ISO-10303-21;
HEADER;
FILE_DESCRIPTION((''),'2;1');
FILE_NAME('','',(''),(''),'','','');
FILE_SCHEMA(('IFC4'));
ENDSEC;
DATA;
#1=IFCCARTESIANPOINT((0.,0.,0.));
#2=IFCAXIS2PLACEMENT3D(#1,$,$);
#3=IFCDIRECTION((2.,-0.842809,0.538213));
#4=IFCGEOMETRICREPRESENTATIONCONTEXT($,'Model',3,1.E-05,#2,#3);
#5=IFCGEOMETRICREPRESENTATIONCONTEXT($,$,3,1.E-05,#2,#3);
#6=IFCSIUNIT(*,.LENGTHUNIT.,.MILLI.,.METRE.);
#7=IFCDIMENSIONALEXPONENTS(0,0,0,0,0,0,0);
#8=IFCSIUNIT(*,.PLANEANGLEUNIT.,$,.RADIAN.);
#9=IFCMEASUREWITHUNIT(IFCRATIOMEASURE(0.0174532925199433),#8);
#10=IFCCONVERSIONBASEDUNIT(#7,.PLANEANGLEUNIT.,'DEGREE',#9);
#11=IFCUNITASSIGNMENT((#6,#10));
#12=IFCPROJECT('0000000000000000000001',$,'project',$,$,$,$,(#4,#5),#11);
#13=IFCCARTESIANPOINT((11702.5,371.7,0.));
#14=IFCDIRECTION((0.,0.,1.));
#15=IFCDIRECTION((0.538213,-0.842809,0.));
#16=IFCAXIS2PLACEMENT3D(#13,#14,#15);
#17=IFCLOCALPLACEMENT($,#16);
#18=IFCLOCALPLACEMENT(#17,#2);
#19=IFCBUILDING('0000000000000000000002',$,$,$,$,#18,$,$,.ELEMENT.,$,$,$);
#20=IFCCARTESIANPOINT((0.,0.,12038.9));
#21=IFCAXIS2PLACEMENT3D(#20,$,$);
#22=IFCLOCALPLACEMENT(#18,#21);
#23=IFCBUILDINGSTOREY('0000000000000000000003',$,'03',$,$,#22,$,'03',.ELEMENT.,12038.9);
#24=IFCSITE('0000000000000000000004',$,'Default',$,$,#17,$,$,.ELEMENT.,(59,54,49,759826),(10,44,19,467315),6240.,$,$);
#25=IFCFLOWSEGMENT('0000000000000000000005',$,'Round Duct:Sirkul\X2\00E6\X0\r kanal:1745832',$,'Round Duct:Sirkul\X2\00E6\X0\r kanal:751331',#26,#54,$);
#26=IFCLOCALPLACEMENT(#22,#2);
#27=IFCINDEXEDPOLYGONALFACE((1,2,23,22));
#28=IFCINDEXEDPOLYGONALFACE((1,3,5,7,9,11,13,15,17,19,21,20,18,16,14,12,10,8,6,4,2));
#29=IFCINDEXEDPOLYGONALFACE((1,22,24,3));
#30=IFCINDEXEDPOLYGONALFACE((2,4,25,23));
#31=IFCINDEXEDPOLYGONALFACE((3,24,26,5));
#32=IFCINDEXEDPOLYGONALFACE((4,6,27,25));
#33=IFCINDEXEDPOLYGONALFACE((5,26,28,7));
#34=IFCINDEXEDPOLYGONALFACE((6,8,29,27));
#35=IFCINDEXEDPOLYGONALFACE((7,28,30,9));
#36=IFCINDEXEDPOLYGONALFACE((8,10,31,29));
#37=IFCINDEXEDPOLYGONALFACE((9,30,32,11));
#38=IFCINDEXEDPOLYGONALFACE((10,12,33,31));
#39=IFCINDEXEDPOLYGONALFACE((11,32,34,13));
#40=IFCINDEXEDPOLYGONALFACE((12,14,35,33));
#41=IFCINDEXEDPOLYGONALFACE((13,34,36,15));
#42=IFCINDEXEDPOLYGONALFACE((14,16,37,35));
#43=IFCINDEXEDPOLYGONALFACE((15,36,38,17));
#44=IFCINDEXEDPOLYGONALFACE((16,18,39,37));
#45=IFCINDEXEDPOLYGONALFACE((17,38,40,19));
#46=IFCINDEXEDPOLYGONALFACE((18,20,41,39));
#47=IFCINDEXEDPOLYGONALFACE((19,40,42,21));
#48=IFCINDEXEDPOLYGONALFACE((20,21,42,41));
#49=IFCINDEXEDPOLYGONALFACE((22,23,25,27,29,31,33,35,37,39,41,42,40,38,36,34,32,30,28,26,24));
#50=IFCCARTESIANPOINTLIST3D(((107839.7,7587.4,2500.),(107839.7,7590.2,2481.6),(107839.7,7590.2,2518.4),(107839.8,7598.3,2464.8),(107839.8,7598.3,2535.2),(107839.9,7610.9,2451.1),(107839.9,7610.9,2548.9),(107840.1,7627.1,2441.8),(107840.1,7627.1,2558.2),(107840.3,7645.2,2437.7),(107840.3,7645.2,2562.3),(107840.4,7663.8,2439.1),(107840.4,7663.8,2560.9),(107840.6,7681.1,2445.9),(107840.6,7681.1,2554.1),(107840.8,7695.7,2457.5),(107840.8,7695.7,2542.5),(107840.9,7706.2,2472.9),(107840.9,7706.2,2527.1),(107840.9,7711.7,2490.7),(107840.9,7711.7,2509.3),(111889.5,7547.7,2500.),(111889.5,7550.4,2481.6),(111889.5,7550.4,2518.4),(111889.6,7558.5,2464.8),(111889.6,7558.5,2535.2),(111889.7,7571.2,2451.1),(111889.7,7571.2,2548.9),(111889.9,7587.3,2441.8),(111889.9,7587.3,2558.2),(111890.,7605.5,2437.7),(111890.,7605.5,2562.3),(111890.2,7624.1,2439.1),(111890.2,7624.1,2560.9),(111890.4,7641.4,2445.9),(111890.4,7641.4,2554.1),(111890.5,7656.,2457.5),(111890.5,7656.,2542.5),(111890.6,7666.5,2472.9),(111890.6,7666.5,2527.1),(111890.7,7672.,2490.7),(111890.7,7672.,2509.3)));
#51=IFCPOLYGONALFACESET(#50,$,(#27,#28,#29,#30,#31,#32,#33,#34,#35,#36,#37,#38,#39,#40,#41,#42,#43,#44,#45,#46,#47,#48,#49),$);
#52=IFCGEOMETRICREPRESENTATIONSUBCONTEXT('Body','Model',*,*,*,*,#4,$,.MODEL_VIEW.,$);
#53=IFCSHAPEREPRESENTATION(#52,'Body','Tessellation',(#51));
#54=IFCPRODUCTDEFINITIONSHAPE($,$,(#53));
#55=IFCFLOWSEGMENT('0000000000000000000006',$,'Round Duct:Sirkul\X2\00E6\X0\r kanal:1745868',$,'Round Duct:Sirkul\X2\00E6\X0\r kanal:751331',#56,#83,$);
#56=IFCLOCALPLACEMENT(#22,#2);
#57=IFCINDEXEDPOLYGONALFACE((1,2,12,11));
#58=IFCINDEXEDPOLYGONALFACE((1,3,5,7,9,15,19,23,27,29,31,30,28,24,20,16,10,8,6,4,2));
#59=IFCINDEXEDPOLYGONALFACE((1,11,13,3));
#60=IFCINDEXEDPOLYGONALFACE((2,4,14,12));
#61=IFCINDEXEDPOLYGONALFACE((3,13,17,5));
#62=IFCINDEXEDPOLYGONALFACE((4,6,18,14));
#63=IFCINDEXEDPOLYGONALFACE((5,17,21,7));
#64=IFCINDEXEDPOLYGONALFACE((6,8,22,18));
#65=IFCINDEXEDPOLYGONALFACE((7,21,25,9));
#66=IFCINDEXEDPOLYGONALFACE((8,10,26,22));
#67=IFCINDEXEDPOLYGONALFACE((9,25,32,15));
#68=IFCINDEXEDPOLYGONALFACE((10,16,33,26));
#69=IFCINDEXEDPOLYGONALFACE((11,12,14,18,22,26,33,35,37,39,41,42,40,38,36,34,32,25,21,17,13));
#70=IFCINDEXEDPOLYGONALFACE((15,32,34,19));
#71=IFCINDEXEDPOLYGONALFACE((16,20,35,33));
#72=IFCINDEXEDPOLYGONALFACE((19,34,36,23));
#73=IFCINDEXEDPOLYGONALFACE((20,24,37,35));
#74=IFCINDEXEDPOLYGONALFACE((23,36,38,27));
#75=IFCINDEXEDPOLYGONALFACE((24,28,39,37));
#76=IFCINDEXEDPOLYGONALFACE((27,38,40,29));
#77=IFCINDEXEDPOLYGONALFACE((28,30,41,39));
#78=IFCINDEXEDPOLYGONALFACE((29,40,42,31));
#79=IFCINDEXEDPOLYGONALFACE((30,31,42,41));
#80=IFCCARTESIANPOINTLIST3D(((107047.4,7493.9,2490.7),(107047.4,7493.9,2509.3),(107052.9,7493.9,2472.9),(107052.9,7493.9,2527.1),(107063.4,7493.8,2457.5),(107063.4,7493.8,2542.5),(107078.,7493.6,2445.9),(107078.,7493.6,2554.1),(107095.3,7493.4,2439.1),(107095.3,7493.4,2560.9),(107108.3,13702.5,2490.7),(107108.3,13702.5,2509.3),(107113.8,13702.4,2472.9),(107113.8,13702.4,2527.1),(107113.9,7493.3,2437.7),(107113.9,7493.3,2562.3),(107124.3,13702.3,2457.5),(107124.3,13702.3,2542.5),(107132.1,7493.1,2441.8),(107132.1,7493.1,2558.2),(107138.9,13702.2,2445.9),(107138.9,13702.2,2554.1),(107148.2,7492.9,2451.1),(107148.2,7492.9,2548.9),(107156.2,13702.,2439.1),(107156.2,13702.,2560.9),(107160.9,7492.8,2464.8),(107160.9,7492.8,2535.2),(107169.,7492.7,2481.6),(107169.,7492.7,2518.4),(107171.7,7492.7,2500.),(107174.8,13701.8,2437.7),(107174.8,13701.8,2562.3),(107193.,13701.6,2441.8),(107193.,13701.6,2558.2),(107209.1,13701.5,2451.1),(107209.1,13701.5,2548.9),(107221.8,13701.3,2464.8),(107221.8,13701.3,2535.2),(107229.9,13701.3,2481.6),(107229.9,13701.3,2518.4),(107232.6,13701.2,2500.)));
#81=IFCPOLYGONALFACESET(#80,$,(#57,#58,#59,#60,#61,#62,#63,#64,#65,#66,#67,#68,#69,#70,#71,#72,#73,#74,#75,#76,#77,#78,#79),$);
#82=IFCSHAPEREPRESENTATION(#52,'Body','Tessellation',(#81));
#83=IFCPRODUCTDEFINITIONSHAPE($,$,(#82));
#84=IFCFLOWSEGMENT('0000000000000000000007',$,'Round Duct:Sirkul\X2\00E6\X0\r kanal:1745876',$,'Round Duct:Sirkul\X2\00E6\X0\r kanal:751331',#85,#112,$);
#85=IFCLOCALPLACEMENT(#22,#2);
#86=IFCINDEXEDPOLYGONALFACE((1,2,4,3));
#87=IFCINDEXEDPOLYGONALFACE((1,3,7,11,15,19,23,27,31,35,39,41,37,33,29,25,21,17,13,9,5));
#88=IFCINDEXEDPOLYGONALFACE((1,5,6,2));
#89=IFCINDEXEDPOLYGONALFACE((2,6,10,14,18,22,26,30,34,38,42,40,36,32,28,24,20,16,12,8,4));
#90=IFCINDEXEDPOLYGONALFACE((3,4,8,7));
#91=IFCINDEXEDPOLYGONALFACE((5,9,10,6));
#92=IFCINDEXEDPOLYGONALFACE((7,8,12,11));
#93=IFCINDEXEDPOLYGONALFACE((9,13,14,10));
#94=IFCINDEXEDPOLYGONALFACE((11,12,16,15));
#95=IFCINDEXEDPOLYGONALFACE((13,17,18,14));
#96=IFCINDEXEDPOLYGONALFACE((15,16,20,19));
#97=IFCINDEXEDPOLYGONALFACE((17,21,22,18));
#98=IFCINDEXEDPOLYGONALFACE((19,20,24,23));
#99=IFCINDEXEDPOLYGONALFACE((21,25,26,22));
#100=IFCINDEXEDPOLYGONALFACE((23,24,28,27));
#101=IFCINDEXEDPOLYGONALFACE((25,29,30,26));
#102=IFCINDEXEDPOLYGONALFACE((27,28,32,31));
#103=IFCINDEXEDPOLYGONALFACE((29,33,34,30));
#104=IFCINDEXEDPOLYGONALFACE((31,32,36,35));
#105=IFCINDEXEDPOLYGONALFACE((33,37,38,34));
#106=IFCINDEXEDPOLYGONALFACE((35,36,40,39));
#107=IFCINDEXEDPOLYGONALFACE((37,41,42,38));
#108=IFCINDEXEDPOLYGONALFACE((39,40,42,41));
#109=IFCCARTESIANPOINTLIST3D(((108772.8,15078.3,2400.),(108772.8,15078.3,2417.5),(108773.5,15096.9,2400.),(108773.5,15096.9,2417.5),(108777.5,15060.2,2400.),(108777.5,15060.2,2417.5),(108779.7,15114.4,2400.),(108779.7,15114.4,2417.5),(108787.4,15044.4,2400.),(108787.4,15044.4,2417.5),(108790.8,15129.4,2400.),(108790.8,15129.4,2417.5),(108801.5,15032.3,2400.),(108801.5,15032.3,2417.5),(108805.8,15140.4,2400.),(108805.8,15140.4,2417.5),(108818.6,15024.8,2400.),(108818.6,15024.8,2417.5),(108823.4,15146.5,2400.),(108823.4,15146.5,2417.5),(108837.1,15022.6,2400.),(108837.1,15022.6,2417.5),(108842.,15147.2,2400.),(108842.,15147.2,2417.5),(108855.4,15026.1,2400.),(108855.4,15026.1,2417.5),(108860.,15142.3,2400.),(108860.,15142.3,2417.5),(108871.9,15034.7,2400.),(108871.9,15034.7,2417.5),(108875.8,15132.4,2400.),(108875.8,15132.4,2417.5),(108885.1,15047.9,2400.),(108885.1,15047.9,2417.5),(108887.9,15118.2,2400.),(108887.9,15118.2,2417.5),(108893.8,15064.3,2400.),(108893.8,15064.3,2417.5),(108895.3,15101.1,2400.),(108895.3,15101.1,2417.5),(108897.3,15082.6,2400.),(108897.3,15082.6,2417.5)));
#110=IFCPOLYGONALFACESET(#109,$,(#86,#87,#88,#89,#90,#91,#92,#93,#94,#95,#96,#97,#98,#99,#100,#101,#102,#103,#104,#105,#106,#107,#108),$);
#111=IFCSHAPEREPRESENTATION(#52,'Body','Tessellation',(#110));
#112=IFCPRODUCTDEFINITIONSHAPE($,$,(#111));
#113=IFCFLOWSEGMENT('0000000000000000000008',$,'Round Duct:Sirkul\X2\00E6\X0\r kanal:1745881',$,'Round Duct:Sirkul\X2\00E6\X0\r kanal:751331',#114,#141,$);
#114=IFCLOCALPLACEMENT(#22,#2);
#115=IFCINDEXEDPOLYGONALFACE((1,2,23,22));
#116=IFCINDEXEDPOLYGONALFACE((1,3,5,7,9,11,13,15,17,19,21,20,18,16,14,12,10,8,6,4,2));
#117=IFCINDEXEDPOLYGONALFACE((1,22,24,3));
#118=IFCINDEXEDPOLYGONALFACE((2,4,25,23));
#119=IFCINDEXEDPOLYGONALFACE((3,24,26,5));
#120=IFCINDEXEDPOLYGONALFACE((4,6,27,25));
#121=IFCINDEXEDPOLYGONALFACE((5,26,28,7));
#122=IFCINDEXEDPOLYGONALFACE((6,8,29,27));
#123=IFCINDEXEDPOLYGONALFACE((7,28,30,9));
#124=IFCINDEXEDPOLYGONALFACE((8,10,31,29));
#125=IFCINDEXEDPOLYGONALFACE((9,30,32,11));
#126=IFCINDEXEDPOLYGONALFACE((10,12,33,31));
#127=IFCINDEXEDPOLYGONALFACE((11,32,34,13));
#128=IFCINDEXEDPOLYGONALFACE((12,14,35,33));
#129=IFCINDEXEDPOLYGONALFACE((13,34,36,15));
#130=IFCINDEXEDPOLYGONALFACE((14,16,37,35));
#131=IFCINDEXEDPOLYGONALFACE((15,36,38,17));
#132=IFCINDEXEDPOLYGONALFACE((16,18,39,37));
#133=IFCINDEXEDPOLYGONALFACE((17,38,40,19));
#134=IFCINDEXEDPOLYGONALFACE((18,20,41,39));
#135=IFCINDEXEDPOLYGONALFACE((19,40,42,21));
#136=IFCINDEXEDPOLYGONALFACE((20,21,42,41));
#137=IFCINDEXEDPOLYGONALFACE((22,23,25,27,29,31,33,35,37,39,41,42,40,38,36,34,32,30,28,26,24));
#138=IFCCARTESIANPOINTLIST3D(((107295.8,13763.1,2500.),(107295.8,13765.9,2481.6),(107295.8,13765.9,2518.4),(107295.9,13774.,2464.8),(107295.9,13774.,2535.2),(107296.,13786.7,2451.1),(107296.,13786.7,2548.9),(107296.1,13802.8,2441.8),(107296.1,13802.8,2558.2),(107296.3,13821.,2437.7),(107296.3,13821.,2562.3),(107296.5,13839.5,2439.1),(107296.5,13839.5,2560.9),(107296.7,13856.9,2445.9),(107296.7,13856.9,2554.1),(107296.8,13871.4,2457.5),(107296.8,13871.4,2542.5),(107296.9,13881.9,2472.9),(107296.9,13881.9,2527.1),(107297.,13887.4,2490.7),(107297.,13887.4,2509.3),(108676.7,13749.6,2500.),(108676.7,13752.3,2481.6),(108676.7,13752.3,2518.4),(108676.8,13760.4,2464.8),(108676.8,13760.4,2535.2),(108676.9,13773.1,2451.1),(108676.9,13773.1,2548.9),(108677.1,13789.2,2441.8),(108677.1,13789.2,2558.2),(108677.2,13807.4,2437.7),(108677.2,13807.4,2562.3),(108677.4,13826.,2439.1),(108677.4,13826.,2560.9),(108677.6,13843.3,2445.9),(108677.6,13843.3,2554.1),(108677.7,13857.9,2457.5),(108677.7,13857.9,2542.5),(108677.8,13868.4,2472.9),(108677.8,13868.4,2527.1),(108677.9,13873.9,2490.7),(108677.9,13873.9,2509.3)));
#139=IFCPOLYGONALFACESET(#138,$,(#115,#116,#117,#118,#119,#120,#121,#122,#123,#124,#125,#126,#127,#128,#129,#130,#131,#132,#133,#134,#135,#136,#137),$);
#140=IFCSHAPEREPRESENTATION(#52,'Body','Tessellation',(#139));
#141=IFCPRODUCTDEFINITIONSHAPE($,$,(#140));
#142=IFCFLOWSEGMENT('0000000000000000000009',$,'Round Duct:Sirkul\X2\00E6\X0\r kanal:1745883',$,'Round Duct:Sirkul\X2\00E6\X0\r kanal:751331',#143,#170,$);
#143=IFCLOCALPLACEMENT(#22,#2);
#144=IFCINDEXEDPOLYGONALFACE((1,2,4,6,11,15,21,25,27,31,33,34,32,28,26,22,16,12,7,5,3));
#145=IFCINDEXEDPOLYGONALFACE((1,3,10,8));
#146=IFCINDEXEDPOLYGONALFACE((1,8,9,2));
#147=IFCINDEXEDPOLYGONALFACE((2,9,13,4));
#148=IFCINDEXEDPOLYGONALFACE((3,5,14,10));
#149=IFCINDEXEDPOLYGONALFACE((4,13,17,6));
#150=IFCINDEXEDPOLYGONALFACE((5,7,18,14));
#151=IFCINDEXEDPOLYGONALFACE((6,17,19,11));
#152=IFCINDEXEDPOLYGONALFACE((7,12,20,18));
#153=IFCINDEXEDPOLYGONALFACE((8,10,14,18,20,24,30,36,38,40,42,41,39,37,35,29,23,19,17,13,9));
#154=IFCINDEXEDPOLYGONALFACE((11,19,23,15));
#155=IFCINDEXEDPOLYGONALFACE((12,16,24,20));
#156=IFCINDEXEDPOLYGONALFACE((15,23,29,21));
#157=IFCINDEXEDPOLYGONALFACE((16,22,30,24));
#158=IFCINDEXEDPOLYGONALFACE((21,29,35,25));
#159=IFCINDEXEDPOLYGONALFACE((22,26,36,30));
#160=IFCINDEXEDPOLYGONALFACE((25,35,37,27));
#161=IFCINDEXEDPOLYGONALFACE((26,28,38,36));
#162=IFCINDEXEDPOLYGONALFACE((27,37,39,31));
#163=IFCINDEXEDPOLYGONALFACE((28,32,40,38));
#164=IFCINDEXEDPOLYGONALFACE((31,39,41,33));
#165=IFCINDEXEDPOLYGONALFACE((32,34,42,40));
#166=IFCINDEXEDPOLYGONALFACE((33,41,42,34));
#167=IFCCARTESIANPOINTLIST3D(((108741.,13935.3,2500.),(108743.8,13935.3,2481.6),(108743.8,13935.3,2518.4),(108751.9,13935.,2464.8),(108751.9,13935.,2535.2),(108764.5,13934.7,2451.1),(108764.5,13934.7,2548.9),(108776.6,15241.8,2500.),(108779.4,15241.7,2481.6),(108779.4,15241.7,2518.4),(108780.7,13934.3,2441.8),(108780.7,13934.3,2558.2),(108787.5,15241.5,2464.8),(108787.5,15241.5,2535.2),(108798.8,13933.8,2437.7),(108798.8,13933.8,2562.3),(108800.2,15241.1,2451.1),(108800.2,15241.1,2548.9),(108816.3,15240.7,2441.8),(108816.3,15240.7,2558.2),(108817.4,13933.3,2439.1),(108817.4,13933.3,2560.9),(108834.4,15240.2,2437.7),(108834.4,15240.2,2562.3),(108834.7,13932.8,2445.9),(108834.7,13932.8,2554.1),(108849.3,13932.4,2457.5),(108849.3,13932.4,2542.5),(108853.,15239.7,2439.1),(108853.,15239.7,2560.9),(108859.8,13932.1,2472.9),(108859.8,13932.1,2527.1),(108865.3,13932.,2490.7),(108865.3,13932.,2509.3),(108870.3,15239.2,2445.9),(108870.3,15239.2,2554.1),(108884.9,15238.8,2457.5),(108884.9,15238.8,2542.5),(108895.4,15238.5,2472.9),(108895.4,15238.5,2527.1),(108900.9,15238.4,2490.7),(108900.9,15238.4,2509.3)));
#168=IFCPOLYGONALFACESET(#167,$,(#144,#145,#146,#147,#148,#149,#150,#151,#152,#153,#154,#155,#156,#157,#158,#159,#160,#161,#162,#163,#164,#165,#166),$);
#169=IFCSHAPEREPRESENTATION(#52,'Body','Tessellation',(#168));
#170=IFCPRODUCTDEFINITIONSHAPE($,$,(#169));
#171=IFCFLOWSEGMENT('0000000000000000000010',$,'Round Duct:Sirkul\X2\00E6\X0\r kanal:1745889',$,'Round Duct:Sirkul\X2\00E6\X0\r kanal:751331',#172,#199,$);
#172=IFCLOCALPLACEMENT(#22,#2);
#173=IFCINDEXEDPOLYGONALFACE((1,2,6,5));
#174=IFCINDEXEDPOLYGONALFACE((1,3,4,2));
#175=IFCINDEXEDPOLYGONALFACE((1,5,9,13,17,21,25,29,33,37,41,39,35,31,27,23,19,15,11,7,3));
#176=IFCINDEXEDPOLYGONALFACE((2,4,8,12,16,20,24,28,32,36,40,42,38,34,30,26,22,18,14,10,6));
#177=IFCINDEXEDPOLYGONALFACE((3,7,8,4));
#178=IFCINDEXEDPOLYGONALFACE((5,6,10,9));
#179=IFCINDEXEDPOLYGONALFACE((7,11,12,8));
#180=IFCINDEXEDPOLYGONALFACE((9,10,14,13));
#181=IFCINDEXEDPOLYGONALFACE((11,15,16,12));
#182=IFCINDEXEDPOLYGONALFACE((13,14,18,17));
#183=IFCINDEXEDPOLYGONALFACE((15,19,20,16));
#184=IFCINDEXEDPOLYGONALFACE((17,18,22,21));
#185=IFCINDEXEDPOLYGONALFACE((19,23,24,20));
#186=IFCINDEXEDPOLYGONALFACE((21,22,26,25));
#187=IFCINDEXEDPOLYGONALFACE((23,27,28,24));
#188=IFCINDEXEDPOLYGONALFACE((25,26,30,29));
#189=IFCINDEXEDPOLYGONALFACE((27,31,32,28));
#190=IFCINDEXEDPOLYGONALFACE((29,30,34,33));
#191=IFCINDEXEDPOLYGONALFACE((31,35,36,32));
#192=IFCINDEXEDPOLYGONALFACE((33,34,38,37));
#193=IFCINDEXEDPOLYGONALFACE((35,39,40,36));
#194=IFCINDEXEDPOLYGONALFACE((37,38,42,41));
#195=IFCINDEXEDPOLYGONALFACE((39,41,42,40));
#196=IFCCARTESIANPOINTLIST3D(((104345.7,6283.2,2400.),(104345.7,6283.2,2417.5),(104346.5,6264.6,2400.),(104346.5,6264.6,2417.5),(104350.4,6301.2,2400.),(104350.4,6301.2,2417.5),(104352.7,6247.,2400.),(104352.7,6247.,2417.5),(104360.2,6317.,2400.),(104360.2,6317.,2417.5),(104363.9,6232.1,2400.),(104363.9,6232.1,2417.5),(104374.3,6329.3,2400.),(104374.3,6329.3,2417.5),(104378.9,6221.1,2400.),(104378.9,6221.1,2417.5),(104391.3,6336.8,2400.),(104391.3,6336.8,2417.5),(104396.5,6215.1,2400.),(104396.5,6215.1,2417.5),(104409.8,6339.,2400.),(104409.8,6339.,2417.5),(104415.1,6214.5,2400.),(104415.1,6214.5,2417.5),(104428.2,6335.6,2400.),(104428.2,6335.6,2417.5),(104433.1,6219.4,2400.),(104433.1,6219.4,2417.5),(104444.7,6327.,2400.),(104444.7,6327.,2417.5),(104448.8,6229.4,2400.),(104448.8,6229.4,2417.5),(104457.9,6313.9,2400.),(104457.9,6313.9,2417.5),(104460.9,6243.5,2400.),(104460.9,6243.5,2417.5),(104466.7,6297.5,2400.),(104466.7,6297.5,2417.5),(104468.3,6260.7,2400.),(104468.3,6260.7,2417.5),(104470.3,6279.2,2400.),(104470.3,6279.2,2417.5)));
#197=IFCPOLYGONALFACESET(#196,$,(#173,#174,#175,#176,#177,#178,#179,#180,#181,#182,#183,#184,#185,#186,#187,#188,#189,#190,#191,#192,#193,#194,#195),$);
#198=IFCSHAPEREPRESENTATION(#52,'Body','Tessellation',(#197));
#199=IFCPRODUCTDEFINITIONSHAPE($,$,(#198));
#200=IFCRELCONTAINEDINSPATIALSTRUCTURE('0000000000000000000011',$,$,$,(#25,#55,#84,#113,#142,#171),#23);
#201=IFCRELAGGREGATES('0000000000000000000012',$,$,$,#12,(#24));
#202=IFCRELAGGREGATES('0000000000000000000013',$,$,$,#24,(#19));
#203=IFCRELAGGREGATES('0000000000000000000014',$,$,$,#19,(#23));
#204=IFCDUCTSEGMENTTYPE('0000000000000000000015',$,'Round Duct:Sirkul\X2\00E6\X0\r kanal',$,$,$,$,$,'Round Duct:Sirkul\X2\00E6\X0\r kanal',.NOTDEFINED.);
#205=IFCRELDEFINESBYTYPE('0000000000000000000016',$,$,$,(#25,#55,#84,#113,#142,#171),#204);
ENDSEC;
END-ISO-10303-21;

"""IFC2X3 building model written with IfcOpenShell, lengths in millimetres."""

from ifc_helpers import new_model, entity, si_unit, converted_unit, direction, frame, frame_2d, origin, origin_2d_with_axis, place, context, subcontext, project, spatial, circle, extrude, type_object, element, save


model = new_model("IFC2X3")

# Units and contexts
model_context = context("Model", 3, precision=1e-05, world=origin(), true_north=direction((2.0, -0.842809, 0.538213)))
context_of_model = context(None, 3, precision=1e-05, world=origin(), true_north=direction((2.0, -0.842809, 0.538213)))
body_context = subcontext(model_context, "Body", "Model", "MODEL_VIEW")
ifc_project = project(units=[si_unit("LENGTHUNIT", "METRE", prefix="MILLI"), converted_unit("PLANEANGLEUNIT", "DEGREE", entity("IfcRatioMeasure", 0.0174532925199433), si_unit("PLANEANGLEUNIT", "RADIAN"), dimensions=[0, 0, 0, 0, 0, 0, 0])], contexts=[model_context, context_of_model])

# Site, building, storey
site_placement = place(None, frame((11702.5, 371.7, 0.0), z_axis=(0.0, 0.0, 1.0), x_axis=(0.538213, -0.842809, 0.0)))
site = spatial("IfcSite", under=ifc_project, at=site_placement, Name="Default", CompositionType="ELEMENT", RefLatitude=(59, 54, 49, 759826), RefLongitude=(10, 44, 19, 467315), RefElevation=6240.0)
building_placement = place(site_placement, origin())
building = spatial("IfcBuilding", under=site, at=building_placement, CompositionType="ELEMENT")
storey_placement = place(building_placement, frame((0.0, 0.0, 12038.9)))
storey = spatial("IfcBuildingStorey", under=building, at=storey_placement, Name="03", LongName="03", CompositionType="ELEMENT", Elevation=12038.9)

# Flow segments
duct_segment_type = type_object("IfcDuctSegmentType", Name="Round Duct:Sirkulær kanal", ElementType="Round Duct:Sirkulær kanal", PredefinedType="NOTDEFINED")
flow_segment_1_placement = place(storey_placement, origin())
element("IfcFlowSegment", 1, at=flow_segment_1_placement, inside=storey, type_object=duct_segment_type, Name="Round Duct:Sirkulær kanal:1745832", ObjectType="Round Duct:Sirkulær kanal:751331", context=body_context, shape_type="SweptSolid", body=[
    extrude(circle(Radius=62.5, at=origin_2d_with_axis()), frame((107840.3, 7649.9, 2500.0), z_axis=(0.999952, -0.00981, 0.0), x_axis=(-0.00981, -0.999952, 0.0)), (0.0, 0.0, 1.0), 4050.0),
])
flow_segment_2_placement = place(storey_placement, origin())
element("IfcFlowSegment", 2, at=flow_segment_2_placement, inside=storey, type_object=duct_segment_type, Name="Round Duct:Sirkulær kanal:1745868", ObjectType="Round Duct:Sirkulær kanal:751331", context=body_context, shape_type="SweptSolid", body=[
    extrude(circle(Radius=62.5, at=origin_2d_with_axis()), frame((107109.2, 7493.3, 2500.0), z_axis=(0.00981, 0.999952, 0.0), x_axis=(0.999952, -0.00981, 0.0)), (0.0, 0.0, 1.0), 6208.9),
])
flow_segment_3_placement = place(storey_placement, origin())
element("IfcFlowSegment", 3, at=flow_segment_3_placement, inside=storey, type_object=duct_segment_type, Name="Round Duct:Sirkulær kanal:1745876", ObjectType="Round Duct:Sirkulær kanal:751331", context=body_context, shape_type="SweptSolid", body=[
    extrude(circle(Radius=62.5, at=frame_2d((0.0, 0.0), x_axis=(1.0, 0.0))), frame((108834.9, 15085.1, 2400.0), z_axis=(0.0, 0.0, 1.0), x_axis=(0.803212, -0.595694, 0.0)), (0.0, 0.0, 1.0), 17.5),
])
flow_segment_4_placement = place(storey_placement, origin())
element("IfcFlowSegment", 4, at=flow_segment_4_placement, inside=storey, type_object=duct_segment_type, Name="Round Duct:Sirkulær kanal:1745881", ObjectType="Round Duct:Sirkulær kanal:751331", context=body_context, shape_type="SweptSolid", body=[
    extrude(circle(Radius=62.5, at=frame_2d((0.0, 0.0), x_axis=(1.0, 0.0))), frame((107296.4, 13825.6, 2500.0), z_axis=(0.999952, -0.009828, 0.0), x_axis=(-0.009828, -0.999952, 0.0)), (0.0, 0.0, 1.0), 1381.0),
])
flow_segment_5_placement = place(storey_placement, origin())
element("IfcFlowSegment", 5, at=flow_segment_5_placement, inside=storey, type_object=duct_segment_type, Name="Round Duct:Sirkulær kanal:1745883", ObjectType="Round Duct:Sirkulær kanal:751331", context=body_context, shape_type="SweptSolid", body=[
    extrude(circle(Radius=62.5, at=origin_2d_with_axis()), frame((108803.5, 13933.6, 2500.0), z_axis=(0.02726, 0.999628, 0.0), x_axis=(-0.999628, 0.02726, 0.0)), (0.0, 0.0, 1.0), 1306.9),
])
flow_segment_6_placement = place(storey_placement, origin())
element("IfcFlowSegment", 6, at=flow_segment_6_placement, inside=storey, type_object=duct_segment_type, Name="Round Duct:Sirkulær kanal:1745889", ObjectType="Round Duct:Sirkulær kanal:751331", context=body_context, shape_type="SweptSolid", body=[
    extrude(circle(Radius=62.5, at=frame_2d((0.0, 0.0), x_axis=(1.0, 0.0))), frame((104407.8, 6276.5, 2400.0), z_axis=(0.0, 0.0, 1.0), x_axis=(0.999095, 0.042537, 0.0)), (0.0, 0.0, 1.0), 17.5),
])

save(model, "model.ifc")
